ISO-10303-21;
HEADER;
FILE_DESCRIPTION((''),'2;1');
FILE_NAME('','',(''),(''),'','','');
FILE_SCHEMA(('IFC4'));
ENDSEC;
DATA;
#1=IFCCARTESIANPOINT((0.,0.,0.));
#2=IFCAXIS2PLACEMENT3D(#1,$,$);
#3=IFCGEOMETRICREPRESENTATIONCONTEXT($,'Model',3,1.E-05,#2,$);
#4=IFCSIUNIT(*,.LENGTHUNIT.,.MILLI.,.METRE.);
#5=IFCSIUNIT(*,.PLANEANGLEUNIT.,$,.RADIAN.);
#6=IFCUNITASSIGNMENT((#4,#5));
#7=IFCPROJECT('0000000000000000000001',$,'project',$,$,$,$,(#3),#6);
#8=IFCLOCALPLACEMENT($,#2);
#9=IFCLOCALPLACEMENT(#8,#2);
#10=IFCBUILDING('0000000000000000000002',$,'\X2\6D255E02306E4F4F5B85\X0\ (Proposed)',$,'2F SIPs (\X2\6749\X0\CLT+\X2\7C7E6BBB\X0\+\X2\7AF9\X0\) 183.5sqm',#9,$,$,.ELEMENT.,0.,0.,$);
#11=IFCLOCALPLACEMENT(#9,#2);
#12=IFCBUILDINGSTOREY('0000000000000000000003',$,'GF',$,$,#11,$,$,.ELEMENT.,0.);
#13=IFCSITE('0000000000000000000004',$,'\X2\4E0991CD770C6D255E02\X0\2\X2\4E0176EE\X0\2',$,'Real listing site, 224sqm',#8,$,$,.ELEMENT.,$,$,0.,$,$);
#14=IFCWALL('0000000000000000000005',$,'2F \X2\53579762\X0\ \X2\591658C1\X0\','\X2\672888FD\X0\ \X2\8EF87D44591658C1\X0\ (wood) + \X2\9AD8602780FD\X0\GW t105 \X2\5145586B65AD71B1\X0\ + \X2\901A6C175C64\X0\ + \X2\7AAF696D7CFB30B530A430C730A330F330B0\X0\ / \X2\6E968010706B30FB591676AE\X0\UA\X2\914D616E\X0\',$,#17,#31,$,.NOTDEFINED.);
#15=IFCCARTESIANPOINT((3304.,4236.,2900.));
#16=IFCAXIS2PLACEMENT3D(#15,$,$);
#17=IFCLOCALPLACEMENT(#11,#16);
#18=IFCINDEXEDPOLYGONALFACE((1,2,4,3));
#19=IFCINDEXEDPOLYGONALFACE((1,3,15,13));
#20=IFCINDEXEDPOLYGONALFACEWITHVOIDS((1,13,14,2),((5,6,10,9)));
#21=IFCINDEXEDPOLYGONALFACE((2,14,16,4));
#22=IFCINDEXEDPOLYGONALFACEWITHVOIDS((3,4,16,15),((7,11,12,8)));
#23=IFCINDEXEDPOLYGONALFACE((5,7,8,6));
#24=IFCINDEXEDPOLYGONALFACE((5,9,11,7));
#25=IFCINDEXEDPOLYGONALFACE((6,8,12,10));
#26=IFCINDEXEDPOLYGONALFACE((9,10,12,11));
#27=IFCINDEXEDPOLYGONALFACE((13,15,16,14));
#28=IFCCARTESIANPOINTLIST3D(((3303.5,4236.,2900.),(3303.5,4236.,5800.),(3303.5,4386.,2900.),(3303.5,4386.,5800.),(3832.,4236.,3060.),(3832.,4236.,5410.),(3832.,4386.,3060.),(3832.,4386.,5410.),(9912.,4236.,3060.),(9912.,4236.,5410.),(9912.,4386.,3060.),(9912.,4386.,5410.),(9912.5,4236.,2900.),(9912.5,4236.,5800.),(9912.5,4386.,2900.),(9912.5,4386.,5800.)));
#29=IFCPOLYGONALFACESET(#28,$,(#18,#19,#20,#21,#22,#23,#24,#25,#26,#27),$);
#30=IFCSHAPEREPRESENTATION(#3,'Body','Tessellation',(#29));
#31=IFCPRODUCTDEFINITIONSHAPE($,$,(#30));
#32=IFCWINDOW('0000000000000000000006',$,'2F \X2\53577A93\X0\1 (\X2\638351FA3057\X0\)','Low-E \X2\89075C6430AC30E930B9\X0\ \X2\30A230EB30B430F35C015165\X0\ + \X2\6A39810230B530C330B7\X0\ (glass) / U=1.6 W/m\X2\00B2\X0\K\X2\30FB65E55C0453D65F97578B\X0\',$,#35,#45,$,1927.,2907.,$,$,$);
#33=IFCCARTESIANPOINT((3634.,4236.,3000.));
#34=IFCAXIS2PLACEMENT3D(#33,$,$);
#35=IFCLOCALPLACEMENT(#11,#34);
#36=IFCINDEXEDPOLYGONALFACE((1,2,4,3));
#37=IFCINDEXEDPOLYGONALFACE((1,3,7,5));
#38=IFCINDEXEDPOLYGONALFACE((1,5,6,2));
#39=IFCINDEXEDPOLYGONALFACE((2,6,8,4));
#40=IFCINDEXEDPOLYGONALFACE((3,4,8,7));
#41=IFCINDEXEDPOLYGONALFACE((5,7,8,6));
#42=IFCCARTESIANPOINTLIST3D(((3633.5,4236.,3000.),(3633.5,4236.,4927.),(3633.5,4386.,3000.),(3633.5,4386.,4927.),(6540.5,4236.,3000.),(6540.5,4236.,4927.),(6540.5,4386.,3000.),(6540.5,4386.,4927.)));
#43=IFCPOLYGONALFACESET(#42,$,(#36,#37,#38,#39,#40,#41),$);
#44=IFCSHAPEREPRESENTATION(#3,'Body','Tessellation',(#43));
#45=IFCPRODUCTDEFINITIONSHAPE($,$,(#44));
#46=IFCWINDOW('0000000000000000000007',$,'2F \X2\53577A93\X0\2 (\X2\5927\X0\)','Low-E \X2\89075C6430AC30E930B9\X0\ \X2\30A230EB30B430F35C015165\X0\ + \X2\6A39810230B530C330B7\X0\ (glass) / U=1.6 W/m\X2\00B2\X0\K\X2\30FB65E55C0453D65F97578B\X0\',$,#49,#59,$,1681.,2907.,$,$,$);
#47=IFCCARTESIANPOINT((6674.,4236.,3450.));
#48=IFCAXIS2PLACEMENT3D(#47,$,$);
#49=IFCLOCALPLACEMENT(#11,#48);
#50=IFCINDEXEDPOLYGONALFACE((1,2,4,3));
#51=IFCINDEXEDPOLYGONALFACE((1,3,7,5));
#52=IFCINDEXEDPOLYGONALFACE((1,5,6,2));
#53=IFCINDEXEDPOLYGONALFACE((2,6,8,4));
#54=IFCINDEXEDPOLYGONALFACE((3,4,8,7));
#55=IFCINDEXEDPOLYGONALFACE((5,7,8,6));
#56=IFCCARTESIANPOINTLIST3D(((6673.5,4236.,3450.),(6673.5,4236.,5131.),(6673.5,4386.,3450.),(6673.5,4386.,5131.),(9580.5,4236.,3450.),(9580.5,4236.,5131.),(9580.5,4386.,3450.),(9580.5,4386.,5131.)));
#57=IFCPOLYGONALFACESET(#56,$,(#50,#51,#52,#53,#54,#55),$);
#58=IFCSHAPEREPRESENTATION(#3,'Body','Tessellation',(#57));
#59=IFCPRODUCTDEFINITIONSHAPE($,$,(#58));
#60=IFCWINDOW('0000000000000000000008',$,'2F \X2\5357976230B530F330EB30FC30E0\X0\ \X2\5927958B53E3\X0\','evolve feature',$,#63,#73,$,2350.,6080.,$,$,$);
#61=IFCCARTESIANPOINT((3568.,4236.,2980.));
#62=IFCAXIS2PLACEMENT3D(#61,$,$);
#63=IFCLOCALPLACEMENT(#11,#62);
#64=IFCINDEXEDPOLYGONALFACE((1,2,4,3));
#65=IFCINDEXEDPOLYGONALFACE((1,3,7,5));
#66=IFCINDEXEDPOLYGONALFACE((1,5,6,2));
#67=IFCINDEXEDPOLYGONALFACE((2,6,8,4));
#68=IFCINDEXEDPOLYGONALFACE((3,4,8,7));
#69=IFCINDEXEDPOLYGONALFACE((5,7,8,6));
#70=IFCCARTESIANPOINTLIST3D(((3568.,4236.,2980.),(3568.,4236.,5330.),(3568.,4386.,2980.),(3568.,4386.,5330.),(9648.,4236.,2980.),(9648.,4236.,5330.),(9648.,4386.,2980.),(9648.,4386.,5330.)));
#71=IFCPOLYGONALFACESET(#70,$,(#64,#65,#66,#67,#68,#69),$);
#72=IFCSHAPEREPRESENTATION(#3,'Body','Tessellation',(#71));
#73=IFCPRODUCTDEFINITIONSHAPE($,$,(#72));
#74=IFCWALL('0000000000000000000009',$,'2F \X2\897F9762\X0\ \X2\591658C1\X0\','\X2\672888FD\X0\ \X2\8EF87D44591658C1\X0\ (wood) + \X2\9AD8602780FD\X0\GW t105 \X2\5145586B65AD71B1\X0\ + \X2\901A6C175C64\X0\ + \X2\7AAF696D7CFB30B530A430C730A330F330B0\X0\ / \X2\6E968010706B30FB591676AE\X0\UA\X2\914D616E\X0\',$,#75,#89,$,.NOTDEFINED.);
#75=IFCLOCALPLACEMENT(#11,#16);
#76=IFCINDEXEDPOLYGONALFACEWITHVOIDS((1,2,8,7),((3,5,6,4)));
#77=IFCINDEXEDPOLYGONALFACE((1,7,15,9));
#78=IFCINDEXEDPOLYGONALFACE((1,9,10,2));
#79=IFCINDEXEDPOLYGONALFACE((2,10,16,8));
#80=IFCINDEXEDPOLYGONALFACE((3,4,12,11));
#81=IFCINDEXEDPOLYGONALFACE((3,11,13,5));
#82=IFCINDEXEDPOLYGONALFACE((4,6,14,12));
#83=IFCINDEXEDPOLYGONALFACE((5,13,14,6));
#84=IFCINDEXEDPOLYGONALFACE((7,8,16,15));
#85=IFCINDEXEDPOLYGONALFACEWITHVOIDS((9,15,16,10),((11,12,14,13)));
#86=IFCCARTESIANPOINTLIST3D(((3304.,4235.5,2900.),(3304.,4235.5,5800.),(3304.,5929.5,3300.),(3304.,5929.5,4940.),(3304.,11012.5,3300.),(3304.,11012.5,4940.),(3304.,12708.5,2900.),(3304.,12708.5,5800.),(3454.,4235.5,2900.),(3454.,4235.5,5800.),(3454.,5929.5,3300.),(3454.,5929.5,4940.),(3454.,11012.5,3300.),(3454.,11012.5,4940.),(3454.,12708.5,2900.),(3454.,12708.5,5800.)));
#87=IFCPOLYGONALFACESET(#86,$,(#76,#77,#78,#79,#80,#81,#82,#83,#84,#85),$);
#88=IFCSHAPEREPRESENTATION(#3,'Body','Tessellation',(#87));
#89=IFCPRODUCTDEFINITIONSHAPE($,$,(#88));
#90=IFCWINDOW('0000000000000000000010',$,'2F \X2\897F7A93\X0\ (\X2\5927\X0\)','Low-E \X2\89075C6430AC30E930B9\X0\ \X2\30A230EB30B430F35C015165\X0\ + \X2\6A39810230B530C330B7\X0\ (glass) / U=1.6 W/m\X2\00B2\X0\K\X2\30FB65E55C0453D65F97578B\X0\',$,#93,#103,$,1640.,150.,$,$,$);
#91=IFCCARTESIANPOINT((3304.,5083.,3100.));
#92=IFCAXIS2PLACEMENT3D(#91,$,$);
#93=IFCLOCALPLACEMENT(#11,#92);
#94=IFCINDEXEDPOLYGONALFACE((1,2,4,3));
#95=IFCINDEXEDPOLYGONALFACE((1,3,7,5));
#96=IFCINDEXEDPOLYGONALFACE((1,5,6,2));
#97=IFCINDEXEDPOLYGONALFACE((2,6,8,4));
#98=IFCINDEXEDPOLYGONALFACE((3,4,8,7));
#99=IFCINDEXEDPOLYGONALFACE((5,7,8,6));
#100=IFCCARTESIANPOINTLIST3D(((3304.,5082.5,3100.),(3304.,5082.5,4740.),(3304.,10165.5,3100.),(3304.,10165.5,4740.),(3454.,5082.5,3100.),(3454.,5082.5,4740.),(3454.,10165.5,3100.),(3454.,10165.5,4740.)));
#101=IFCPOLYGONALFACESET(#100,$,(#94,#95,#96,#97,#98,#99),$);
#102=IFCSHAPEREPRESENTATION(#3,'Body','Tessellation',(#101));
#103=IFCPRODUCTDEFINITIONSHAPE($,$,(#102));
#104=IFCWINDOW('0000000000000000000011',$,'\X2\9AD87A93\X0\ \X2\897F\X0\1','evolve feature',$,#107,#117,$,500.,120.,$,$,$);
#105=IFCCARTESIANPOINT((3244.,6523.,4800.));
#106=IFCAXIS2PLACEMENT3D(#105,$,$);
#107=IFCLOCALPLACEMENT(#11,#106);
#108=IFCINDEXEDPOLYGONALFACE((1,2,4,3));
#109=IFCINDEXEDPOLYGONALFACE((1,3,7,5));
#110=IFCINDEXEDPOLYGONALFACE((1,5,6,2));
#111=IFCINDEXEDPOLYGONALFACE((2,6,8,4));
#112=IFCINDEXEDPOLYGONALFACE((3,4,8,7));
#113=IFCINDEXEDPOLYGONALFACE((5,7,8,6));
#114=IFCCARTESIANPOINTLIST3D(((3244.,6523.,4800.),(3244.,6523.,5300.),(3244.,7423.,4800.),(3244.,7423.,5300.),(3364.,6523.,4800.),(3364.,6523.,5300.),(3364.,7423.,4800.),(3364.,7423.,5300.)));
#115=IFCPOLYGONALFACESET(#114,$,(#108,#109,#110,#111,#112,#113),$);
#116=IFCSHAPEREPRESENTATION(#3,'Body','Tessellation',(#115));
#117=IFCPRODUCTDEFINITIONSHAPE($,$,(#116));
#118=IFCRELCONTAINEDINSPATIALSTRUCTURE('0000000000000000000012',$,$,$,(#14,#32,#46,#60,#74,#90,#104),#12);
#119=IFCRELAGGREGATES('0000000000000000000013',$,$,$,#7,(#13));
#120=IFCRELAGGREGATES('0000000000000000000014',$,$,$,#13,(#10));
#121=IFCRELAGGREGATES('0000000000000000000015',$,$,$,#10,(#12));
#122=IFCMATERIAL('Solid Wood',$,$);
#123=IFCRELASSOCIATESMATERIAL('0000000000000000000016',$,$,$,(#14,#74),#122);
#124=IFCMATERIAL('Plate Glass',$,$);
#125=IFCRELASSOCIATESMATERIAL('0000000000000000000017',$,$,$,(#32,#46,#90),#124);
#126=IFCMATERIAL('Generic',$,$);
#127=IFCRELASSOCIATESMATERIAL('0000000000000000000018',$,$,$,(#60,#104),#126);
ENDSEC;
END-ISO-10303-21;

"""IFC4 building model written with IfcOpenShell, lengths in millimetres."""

from ifc_helpers import new_model, si_unit, frame, frame_2d, origin, place, context, project, spatial, rectangle, extrude, material, element, fill, save


model = new_model("IFC4")

# Units and contexts
model_context = context("Model", 3, precision=1e-05, world=origin())
ifc_project = project(units=[si_unit("LENGTHUNIT", "METRE", prefix="MILLI"), si_unit("PLANEANGLEUNIT", "RADIAN")], contexts=[model_context])

# Site, building, storey
site_placement = place(None, origin())
site = spatial("IfcSite", under=ifc_project, at=site_placement, Name="三重県津市2丁目2", ObjectType="Real listing site, 224sqm", CompositionType="ELEMENT", RefElevation=0.0)
building_placement = place(site_placement, origin())
building = spatial("IfcBuilding", under=site, at=building_placement, Name="津市の住宅 (Proposed)", ObjectType="2F SIPs (杉CLT+籾殻+竹) 183.5sqm", CompositionType="ELEMENT", ElevationOfRefHeight=0.0, ElevationOfTerrain=0.0)
storey_placement = place(building_placement, origin())
storey = spatial("IfcBuildingStorey", under=building, at=storey_placement, Name="GF", CompositionType="ELEMENT", Elevation=0.0)

# Shared definitions
ifc_material_1 = material(Name="Solid Wood")
ifc_material_2 = material(Name="Generic")

# Shared definitions
ifc_material_3 = material(Name="Plate Glass")

# Walls, openings, windows
wall_1_placement = place(storey_placement, frame((3304.0, 4236.0, 2900.0)))
wall_1 = element("IfcWall", 1, at=wall_1_placement, inside=storey, material=ifc_material_1, Name="2F 南面 外壁", Description="木製 軸組外壁 (wood) + 高性能GW t105 充填断熱 + 通気層 + 窯業系サイディング / 準耐火・外皮UA配慮", PredefinedType="NOTDEFINED", context=model_context, shape_type="SweptSolid", body=[
    extrude(rectangle(XDim=6609.0, YDim=150.0, at=frame_2d((3304.0, 75.0))), frame((3304.0, 4236.0, 2900.0)), (0.0, 0.0, 1.0), 2900.0),
])
opening_1_placement = place(storey_placement, frame((3634.0, 4236.0, 3000.0)))
opening_1 = element("IfcOpeningElement", 2, at=opening_1_placement, cuts=wall_1, PredefinedType="NOTDEFINED", context=model_context, shape_type="SweptSolid", body=[
    extrude(rectangle(XDim=2907.0, YDim=150.0, at=frame_2d((1453.0, 75.0))), frame((3634.0, 4236.0, 3000.0)), (0.0, 0.0, 1.0), 1927.0),
])
opening_2_placement = place(storey_placement, frame((6674.0, 4236.0, 3450.0)))
opening_2 = element("IfcOpeningElement", 3, at=opening_2_placement, cuts=wall_1, PredefinedType="NOTDEFINED", context=model_context, shape_type="SweptSolid", body=[
    extrude(rectangle(XDim=2907.0, YDim=150.0, at=frame_2d((1453.0, 75.0))), frame((6674.0, 4236.0, 3450.0)), (0.0, 0.0, 1.0), 1681.0),
])
opening_3_placement = place(storey_placement, frame((3568.0, 4236.0, 2980.0)))
opening_3 = element("IfcOpeningElement", 4, at=opening_3_placement, cuts=wall_1, PredefinedType="NOTDEFINED", context=model_context, shape_type="SweptSolid", body=[
    extrude(rectangle(XDim=6080.0, YDim=150.0, at=frame_2d((3040.0, 75.0))), frame((3568.0, 4236.0, 2980.0)), (0.0, 0.0, 1.0), 2350.0),
])
window_1_placement = place(storey_placement, frame((3634.0, 4236.0, 3000.0)))
window_1 = element("IfcWindow", 5, at=window_1_placement, inside=storey, material=ifc_material_3, Name="2F 南窓1 (掃出し)", Description="Low-E 複層ガラス アルゴン封入 + 樹脂サッシ (glass) / U=1.6 W/m²K・日射取得型", OverallHeight=1927.0, OverallWidth=2907.0, context=model_context, shape_type="SweptSolid", body=[
    extrude(rectangle(XDim=2907.0, YDim=150.0, at=frame_2d((1453.0, 75.0))), frame((3634.0, 4236.0, 3000.0)), (0.0, 0.0, 1.0), 1927.0),
])
fill(opening_1, window_1)
window_2_placement = place(storey_placement, frame((6674.0, 4236.0, 3450.0)))
window_2 = element("IfcWindow", 6, at=window_2_placement, inside=storey, material=ifc_material_3, Name="2F 南窓2 (大)", Description="Low-E 複層ガラス アルゴン封入 + 樹脂サッシ (glass) / U=1.6 W/m²K・日射取得型", OverallHeight=1681.0, OverallWidth=2907.0, context=model_context, shape_type="SweptSolid", body=[
    extrude(rectangle(XDim=2907.0, YDim=150.0, at=frame_2d((1453.0, 75.0))), frame((6674.0, 4236.0, 3450.0)), (0.0, 0.0, 1.0), 1681.0),
])
fill(opening_2, window_2)
window_3_placement = place(storey_placement, frame((3568.0, 4236.0, 2980.0)))
window_3 = element("IfcWindow", 7, at=window_3_placement, inside=storey, material=ifc_material_2, Name="2F 南面サンルーム 大開口", Description="evolve feature", OverallHeight=2350.0, OverallWidth=6080.0, context=model_context, shape_type="SweptSolid", body=[
    extrude(rectangle(XDim=6080.0, YDim=150.0, at=frame_2d((3040.0, 75.0))), frame((3568.0, 4236.0, 2980.0)), (0.0, 0.0, 1.0), 2350.0),
])
fill(opening_3, window_3)
wall_2_placement = place(storey_placement, frame((3304.0, 4236.0, 2900.0)))
wall_2 = element("IfcWall", 8, at=wall_2_placement, inside=storey, material=ifc_material_1, Name="2F 西面 外壁", Description="木製 軸組外壁 (wood) + 高性能GW t105 充填断熱 + 通気層 + 窯業系サイディング / 準耐火・外皮UA配慮", PredefinedType="NOTDEFINED", context=model_context, shape_type="SweptSolid", body=[
    extrude(rectangle(XDim=150.0, YDim=8473.0, at=frame_2d((75.0, 4236.0))), frame((3304.0, 4236.0, 2900.0)), (0.0, 0.0, 1.0), 2900.0),
])
opening_4_placement = place(storey_placement, frame((3304.0, 5083.0, 3100.0)))
opening_4 = element("IfcOpeningElement", 9, at=opening_4_placement, cuts=wall_2, PredefinedType="NOTDEFINED", context=model_context, shape_type="SweptSolid", body=[
    extrude(rectangle(XDim=150.0, YDim=5083.0, at=frame_2d((75.0, 2541.0))), frame((3304.0, 5083.0, 3100.0)), (0.0, 0.0, 1.0), 1640.0),
])
opening_5_placement = place(storey_placement, frame((3244.0, 6523.0, 4800.0)))
opening_5 = element("IfcOpeningElement", 10, at=opening_5_placement, cuts=wall_2, PredefinedType="NOTDEFINED", context=model_context, shape_type="SweptSolid", body=[
    extrude(rectangle(XDim=120.0, YDim=900.0, at=frame_2d((60.0, 450.0))), frame((3244.0, 6523.0, 4800.0)), (0.0, 0.0, 1.0), 500.0),
])
window_4_placement = place(storey_placement, frame((3304.0, 5083.0, 3100.0)))
window_4 = element("IfcWindow", 11, at=window_4_placement, inside=storey, material=ifc_material_3, Name="2F 西窓 (大)", Description="Low-E 複層ガラス アルゴン封入 + 樹脂サッシ (glass) / U=1.6 W/m²K・日射取得型", OverallHeight=1640.0, OverallWidth=150.0, context=model_context, shape_type="SweptSolid", body=[
    extrude(rectangle(XDim=150.0, YDim=5083.0, at=frame_2d((75.0, 2541.0))), frame((3304.0, 5083.0, 3100.0)), (0.0, 0.0, 1.0), 1640.0),
])
fill(opening_4, window_4)
window_5_placement = place(storey_placement, frame((3244.0, 6523.0, 4800.0)))
window_5 = element("IfcWindow", 12, at=window_5_placement, inside=storey, material=ifc_material_2, Name="高窓 西1", Description="evolve feature", OverallHeight=500.0, OverallWidth=120.0, context=model_context, shape_type="SweptSolid", body=[
    extrude(rectangle(XDim=120.0, YDim=900.0, at=frame_2d((60.0, 450.0))), frame((3244.0, 6523.0, 4800.0)), (0.0, 0.0, 1.0), 500.0),
])
fill(opening_5, window_5)

save(model, "model.ifc")
